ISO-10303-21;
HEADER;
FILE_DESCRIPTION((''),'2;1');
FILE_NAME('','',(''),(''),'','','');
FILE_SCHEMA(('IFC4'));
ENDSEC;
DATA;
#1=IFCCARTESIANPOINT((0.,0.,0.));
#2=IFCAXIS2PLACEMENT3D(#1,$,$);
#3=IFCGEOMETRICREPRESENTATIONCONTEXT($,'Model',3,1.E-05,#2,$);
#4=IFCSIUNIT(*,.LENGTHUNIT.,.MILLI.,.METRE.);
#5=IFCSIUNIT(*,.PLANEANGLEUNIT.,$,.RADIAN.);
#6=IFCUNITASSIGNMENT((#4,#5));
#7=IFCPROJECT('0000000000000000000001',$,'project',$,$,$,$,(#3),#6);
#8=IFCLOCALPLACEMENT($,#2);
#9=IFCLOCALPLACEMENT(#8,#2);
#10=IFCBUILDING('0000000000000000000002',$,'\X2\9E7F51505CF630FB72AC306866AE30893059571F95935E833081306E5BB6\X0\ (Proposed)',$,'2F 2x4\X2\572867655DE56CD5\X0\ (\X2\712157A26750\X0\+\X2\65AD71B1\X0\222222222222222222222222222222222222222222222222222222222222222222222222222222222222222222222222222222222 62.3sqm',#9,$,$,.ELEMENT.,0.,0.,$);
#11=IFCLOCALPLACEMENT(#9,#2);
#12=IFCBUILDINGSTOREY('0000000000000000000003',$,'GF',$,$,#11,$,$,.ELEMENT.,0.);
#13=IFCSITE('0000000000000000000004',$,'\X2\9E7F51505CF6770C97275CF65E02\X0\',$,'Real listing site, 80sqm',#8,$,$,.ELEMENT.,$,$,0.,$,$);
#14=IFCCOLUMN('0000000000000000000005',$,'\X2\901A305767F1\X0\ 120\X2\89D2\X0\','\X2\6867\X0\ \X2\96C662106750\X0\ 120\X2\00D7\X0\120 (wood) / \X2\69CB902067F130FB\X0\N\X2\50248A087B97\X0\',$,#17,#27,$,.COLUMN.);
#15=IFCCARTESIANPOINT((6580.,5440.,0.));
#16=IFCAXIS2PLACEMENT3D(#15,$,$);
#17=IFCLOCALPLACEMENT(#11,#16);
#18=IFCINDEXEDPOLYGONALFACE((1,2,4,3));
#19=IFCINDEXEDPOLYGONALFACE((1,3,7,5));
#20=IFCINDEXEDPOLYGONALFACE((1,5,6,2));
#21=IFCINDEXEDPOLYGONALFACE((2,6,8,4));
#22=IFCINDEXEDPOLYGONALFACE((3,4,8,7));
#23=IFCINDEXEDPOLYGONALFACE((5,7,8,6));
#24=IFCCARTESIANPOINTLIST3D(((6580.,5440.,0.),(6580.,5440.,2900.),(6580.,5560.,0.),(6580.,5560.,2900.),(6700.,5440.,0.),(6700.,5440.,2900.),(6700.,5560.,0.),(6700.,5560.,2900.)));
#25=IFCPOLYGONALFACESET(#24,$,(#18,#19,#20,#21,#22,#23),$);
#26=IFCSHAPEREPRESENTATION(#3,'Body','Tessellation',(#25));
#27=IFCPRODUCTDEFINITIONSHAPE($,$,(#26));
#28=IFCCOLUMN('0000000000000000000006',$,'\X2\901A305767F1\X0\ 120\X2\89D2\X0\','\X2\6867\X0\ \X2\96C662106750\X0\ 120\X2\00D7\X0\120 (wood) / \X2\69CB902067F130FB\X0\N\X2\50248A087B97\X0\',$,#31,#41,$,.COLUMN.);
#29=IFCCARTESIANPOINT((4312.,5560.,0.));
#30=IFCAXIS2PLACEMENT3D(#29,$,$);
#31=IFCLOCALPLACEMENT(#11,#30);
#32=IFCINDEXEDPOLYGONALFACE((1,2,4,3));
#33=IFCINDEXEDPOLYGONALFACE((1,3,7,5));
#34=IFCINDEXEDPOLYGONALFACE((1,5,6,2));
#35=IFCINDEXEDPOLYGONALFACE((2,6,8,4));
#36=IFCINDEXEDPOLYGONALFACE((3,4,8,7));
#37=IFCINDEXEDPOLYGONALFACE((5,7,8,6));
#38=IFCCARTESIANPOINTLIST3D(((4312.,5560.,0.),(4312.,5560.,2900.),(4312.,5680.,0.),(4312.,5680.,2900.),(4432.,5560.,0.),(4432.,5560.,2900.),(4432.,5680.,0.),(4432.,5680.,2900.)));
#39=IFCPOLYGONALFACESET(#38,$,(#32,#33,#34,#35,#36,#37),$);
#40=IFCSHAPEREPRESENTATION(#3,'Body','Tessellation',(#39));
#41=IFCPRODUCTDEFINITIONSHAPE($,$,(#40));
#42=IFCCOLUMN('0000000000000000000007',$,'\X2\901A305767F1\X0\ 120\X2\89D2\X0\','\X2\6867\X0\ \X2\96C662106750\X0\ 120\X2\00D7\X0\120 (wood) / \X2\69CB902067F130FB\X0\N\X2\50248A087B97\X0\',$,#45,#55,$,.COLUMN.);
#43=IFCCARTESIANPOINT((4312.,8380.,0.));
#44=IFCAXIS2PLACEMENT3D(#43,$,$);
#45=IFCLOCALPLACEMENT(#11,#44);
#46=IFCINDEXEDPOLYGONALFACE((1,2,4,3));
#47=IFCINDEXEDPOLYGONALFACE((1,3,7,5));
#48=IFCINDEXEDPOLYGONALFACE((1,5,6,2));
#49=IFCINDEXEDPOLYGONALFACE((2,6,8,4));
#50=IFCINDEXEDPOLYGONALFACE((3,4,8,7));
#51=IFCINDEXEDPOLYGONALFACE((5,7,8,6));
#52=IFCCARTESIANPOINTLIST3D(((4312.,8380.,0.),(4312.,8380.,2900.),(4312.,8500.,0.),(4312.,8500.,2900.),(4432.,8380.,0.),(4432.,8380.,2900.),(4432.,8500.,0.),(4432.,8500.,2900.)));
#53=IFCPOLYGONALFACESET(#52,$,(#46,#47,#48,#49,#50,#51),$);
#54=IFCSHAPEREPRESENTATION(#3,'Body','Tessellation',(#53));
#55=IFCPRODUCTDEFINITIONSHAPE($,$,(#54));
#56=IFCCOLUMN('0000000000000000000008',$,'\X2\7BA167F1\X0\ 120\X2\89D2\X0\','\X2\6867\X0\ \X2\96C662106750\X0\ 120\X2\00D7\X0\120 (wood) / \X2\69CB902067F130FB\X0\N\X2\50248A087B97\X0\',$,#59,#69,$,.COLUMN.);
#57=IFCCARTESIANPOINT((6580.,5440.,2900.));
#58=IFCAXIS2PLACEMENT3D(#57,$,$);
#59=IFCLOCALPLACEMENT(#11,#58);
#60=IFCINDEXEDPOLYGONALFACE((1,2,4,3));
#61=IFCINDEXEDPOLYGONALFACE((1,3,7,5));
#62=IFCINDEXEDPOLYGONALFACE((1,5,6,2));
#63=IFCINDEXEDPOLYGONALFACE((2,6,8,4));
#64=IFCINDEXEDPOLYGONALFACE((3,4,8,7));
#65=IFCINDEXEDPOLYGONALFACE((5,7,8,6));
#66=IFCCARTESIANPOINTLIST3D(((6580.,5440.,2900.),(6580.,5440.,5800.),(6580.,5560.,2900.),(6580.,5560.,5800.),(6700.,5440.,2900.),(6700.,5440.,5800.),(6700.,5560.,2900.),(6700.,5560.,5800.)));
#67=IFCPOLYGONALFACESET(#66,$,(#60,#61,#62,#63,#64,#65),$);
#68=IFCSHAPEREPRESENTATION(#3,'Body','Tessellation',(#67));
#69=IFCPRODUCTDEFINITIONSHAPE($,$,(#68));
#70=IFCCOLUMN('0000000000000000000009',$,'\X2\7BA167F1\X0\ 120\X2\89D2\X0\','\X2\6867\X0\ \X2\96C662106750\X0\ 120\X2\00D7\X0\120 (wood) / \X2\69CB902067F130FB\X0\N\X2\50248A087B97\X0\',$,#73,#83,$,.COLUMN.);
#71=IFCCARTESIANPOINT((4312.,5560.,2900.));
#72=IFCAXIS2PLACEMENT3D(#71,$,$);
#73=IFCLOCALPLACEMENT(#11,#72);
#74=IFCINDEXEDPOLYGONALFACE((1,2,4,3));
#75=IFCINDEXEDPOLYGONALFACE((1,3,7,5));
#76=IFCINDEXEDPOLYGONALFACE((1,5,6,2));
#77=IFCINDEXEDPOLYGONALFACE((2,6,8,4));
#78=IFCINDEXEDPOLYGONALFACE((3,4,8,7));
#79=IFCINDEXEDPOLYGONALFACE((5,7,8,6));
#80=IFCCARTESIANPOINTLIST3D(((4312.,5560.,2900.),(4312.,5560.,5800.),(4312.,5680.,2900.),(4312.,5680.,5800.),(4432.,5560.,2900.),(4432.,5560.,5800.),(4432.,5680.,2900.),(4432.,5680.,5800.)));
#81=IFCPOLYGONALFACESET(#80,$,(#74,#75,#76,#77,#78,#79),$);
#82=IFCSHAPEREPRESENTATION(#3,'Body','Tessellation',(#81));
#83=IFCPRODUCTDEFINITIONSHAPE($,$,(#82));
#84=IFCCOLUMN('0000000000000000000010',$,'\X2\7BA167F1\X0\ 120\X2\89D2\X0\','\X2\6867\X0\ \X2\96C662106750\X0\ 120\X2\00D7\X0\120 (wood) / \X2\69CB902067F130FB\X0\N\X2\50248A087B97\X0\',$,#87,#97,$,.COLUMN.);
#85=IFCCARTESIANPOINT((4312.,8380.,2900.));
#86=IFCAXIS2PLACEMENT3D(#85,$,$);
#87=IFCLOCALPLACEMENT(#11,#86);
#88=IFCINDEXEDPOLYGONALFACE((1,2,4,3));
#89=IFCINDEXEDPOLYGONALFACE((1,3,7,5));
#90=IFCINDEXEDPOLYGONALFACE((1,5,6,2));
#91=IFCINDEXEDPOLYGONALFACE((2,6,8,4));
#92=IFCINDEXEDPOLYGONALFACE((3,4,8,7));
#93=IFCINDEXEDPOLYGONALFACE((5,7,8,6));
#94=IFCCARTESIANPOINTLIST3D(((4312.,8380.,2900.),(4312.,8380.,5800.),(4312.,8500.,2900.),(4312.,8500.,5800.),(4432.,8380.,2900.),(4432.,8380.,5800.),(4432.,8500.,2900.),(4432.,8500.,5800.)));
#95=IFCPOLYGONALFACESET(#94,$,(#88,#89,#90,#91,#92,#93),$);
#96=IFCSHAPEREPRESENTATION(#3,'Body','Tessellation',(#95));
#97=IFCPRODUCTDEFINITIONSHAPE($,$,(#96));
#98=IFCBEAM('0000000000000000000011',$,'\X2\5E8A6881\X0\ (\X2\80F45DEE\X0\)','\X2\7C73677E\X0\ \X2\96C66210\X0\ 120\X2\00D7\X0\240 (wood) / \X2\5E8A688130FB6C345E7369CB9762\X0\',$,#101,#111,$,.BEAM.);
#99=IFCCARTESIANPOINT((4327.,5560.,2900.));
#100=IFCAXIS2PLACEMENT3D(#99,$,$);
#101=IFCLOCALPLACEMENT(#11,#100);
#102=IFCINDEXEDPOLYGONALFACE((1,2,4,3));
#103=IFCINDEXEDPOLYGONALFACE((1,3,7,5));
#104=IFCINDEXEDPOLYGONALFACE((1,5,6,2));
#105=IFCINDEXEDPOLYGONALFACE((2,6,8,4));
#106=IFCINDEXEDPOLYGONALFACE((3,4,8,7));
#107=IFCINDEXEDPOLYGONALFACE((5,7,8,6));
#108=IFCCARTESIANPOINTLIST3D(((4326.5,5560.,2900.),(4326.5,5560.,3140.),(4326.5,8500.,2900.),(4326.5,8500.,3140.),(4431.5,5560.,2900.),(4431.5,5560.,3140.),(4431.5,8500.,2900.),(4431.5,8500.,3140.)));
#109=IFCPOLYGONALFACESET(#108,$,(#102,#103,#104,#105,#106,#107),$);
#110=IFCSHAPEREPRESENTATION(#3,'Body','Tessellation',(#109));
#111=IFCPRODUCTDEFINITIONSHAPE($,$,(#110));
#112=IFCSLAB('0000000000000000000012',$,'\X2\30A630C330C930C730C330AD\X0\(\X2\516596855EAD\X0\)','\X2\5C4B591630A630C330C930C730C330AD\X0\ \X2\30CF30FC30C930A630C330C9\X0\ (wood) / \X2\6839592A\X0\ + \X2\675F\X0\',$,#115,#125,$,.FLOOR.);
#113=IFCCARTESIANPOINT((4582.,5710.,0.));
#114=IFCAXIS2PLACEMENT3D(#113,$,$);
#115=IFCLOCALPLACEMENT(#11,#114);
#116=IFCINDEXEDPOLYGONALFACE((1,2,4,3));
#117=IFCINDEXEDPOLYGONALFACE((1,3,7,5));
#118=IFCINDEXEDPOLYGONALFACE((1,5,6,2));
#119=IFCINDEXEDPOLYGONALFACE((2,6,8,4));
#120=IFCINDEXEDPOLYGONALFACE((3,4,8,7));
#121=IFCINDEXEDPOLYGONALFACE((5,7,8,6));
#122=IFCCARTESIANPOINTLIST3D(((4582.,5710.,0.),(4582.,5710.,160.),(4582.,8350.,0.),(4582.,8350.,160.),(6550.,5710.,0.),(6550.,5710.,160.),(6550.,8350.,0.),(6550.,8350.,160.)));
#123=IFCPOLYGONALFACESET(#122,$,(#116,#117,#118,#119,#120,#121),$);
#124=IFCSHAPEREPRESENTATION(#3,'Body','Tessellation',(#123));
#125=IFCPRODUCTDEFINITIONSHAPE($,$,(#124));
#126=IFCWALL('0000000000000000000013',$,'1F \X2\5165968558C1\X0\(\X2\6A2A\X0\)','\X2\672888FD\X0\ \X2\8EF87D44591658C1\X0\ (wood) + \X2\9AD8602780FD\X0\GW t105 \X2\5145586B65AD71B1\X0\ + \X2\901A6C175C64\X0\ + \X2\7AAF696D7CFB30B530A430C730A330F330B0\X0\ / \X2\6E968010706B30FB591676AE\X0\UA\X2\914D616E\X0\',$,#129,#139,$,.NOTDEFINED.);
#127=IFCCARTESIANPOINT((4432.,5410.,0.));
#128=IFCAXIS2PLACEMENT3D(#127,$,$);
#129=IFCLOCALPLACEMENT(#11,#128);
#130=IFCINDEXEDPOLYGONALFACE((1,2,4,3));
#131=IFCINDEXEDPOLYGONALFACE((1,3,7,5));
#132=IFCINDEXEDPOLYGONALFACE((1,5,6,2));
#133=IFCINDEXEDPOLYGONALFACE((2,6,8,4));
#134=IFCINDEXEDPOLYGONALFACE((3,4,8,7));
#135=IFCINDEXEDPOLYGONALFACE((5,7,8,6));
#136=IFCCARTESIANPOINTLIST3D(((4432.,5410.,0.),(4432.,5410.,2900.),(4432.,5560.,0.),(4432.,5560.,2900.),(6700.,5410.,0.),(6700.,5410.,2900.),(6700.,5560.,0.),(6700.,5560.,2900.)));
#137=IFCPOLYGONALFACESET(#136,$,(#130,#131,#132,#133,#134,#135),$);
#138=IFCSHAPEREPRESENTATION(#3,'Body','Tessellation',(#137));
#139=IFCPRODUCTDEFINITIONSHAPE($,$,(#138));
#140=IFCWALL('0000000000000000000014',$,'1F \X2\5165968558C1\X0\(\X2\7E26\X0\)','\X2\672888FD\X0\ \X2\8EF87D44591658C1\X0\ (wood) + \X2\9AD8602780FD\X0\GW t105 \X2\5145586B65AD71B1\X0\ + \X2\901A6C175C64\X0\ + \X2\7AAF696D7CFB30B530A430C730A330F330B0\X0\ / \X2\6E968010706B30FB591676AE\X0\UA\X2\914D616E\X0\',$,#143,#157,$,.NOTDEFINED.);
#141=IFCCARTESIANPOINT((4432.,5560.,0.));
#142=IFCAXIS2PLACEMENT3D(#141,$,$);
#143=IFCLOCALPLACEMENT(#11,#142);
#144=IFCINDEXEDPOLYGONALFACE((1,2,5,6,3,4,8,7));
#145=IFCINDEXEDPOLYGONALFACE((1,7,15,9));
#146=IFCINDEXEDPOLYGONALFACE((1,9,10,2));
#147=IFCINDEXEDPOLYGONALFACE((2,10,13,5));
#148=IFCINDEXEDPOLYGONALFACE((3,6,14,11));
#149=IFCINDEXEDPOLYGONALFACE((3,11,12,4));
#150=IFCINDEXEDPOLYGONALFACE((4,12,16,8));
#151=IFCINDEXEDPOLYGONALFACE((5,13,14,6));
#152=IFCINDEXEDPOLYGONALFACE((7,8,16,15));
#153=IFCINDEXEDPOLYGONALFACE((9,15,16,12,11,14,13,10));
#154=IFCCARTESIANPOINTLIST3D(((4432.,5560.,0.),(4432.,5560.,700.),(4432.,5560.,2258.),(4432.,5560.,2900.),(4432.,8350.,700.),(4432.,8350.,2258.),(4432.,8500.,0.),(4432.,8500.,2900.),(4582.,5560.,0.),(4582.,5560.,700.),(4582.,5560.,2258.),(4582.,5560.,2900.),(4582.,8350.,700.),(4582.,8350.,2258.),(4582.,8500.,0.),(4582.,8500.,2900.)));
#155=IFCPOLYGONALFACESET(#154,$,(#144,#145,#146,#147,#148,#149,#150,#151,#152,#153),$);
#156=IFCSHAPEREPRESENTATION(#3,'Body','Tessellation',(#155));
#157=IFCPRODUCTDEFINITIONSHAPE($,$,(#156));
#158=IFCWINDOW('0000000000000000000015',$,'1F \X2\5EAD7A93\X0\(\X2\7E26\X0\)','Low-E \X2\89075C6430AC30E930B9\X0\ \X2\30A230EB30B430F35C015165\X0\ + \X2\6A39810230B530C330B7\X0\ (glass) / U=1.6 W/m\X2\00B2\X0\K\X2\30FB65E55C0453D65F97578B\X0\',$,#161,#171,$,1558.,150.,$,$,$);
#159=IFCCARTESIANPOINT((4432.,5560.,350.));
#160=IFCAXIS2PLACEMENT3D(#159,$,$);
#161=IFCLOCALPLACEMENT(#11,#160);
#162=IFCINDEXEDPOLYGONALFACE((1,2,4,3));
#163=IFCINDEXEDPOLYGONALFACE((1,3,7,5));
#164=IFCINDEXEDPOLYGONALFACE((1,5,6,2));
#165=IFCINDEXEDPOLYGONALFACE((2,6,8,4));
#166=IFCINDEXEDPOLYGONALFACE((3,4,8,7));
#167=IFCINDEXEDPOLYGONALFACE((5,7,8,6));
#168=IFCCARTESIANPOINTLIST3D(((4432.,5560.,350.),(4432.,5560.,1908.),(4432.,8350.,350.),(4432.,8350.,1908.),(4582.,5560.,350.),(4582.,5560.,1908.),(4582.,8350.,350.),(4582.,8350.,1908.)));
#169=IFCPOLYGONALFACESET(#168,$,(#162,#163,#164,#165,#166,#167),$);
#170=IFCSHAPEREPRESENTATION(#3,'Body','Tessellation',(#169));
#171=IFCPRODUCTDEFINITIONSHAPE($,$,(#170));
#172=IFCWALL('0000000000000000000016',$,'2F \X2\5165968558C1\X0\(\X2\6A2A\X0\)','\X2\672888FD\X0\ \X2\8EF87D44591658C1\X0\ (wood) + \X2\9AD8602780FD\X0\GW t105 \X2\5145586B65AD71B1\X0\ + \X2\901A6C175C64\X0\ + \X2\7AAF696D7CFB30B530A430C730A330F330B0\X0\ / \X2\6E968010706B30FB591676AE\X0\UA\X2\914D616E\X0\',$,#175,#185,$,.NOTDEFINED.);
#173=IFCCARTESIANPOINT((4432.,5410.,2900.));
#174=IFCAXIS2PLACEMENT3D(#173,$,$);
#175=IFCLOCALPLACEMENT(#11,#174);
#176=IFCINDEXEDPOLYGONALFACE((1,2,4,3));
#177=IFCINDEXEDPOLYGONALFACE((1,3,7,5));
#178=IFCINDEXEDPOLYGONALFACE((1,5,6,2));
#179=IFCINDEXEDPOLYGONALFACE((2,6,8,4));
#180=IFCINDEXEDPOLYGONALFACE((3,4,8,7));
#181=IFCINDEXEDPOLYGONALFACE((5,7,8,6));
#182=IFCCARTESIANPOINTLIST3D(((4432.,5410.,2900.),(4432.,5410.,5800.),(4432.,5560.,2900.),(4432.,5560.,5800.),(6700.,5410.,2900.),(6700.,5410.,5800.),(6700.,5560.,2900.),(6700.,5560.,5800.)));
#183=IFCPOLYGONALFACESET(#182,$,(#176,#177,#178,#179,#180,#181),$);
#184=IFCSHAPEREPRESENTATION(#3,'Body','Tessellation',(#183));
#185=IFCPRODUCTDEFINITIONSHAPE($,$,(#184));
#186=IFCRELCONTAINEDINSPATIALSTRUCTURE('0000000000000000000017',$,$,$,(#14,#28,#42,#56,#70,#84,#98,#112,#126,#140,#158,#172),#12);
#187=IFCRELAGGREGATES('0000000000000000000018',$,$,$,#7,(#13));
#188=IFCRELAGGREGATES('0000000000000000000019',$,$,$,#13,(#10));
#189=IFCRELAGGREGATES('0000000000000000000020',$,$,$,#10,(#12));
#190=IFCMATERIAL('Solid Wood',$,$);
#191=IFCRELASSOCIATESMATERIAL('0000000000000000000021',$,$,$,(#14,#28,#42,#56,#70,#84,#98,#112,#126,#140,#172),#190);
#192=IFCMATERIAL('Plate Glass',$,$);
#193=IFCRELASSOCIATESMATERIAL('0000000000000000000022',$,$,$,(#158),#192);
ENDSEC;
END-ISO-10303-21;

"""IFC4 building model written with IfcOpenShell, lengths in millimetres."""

from ifc_helpers import new_model, si_unit, frame, frame_2d, origin, place, context, project, spatial, rectangle, extrude, material, element, fill, save


model = new_model("IFC4")

# Units and contexts
model_context = context("Model", 3, precision=1e-05, world=origin())
ifc_project = project(units=[si_unit("LENGTHUNIT", "METRE", prefix="MILLI"), si_unit("PLANEANGLEUNIT", "RADIAN")], contexts=[model_context])

# Site, building, storey
site_placement = place(None, origin())
site = spatial("IfcSite", under=ifc_project, at=site_placement, Name="鹿児島県霧島市", ObjectType="Real listing site, 80sqm", CompositionType="ELEMENT", RefElevation=0.0)
building_placement = place(site_placement, origin())
building = spatial("IfcBuilding", under=site, at=building_placement, Name="鹿児島・犬と暮らす土間広めの家 (Proposed)", ObjectType="2F 2x4在来工法 (無垢材+断熱222222222222222222222222222222222222222222222222222222222222222222222222222222222222222222222222222222222 62.3sqm", CompositionType="ELEMENT", ElevationOfRefHeight=0.0, ElevationOfTerrain=0.0)
storey_placement = place(building_placement, origin())
storey = spatial("IfcBuildingStorey", under=building, at=storey_placement, Name="GF", CompositionType="ELEMENT", Elevation=0.0)

# Columns
ifc_material_1 = material(Name="Solid Wood")
column_1_placement = place(storey_placement, frame((6580.0, 5440.0, 0.0)))
element("IfcColumn", 1, at=column_1_placement, inside=storey, material=ifc_material_1, Name="通し柱 120角", Description="桧 集成材 120×120 (wood) / 構造柱・N値計算", PredefinedType="COLUMN", context=model_context, shape_type="SweptSolid", body=[
    extrude(rectangle(XDim=120.0, YDim=120.0, at=frame_2d((60.0, 60.0))), frame((6580.0, 5440.0, 0.0)), (0.0, 0.0, 1.0), 2900.0),
])
column_2_placement = place(storey_placement, frame((4312.0, 5560.0, 0.0)))
element("IfcColumn", 2, at=column_2_placement, inside=storey, material=ifc_material_1, Name="通し柱 120角", Description="桧 集成材 120×120 (wood) / 構造柱・N値計算", PredefinedType="COLUMN", context=model_context, shape_type="SweptSolid", body=[
    extrude(rectangle(XDim=120.0, YDim=120.0, at=frame_2d((60.0, 60.0))), frame((4312.0, 5560.0, 0.0)), (0.0, 0.0, 1.0), 2900.0),
])
column_3_placement = place(storey_placement, frame((4312.0, 8380.0, 0.0)))
element("IfcColumn", 3, at=column_3_placement, inside=storey, material=ifc_material_1, Name="通し柱 120角", Description="桧 集成材 120×120 (wood) / 構造柱・N値計算", PredefinedType="COLUMN", context=model_context, shape_type="SweptSolid", body=[
    extrude(rectangle(XDim=120.0, YDim=120.0, at=frame_2d((60.0, 60.0))), frame((4312.0, 8380.0, 0.0)), (0.0, 0.0, 1.0), 2900.0),
])
column_4_placement = place(storey_placement, frame((6580.0, 5440.0, 2900.0)))
element("IfcColumn", 4, at=column_4_placement, inside=storey, material=ifc_material_1, Name="管柱 120角", Description="桧 集成材 120×120 (wood) / 構造柱・N値計算", PredefinedType="COLUMN", context=model_context, shape_type="SweptSolid", body=[
    extrude(rectangle(XDim=120.0, YDim=120.0, at=frame_2d((60.0, 60.0))), frame((6580.0, 5440.0, 2900.0)), (0.0, 0.0, 1.0), 2900.0),
])
column_5_placement = place(storey_placement, frame((4312.0, 5560.0, 2900.0)))
element("IfcColumn", 5, at=column_5_placement, inside=storey, material=ifc_material_1, Name="管柱 120角", Description="桧 集成材 120×120 (wood) / 構造柱・N値計算", PredefinedType="COLUMN", context=model_context, shape_type="SweptSolid", body=[
    extrude(rectangle(XDim=120.0, YDim=120.0, at=frame_2d((60.0, 60.0))), frame((4312.0, 5560.0, 2900.0)), (0.0, 0.0, 1.0), 2900.0),
])
column_6_placement = place(storey_placement, frame((4312.0, 8380.0, 2900.0)))
element("IfcColumn", 6, at=column_6_placement, inside=storey, material=ifc_material_1, Name="管柱 120角", Description="桧 集成材 120×120 (wood) / 構造柱・N値計算", PredefinedType="COLUMN", context=model_context, shape_type="SweptSolid", body=[
    extrude(rectangle(XDim=120.0, YDim=120.0, at=frame_2d((60.0, 60.0))), frame((4312.0, 8380.0, 2900.0)), (0.0, 0.0, 1.0), 2900.0),
])

# Beam
beam_1_placement = place(storey_placement, frame((4327.0, 5560.0, 2900.0)))
element("IfcBeam", 7, at=beam_1_placement, inside=storey, material=ifc_material_1, Name="床梁 (胴差)", Description="米松 集成 120×240 (wood) / 床梁・水平構面", PredefinedType="BEAM", context=model_context, shape_type="SweptSolid", body=[
    extrude(rectangle(XDim=105.0, YDim=2940.0, at=frame_2d((52.0, 1470.0))), frame((4327.0, 5560.0, 2900.0)), (0.0, 0.0, 1.0), 240.0),
])

# Slab
slab_placement = place(storey_placement, frame((4582.0, 5710.0, 0.0)))
element("IfcSlab", 8, at=slab_placement, inside=storey, material=ifc_material_1, Name="ウッドデッキ(入隅庭)", Description="屋外ウッドデッキ ハードウッド (wood) / 根太 + 束", PredefinedType="FLOOR", context=model_context, shape_type="SweptSolid", body=[
    extrude(rectangle(XDim=1968.0, YDim=2640.0, at=frame_2d((984.0, 1320.0))), frame((4582.0, 5710.0, 0.0)), (0.0, 0.0, 1.0), 160.0),
])

# Wall
wall_1_placement = place(storey_placement, frame((4432.0, 5410.0, 0.0)))
element("IfcWall", 9, at=wall_1_placement, inside=storey, material=ifc_material_1, Name="1F 入隅壁(横)", Description="木製 軸組外壁 (wood) + 高性能GW t105 充填断熱 + 通気層 + 窯業系サイディング / 準耐火・外皮UA配慮", PredefinedType="NOTDEFINED", context=model_context, shape_type="SweptSolid", body=[
    extrude(rectangle(XDim=2268.0, YDim=150.0, at=frame_2d((1134.0, 75.0))), frame((4432.0, 5410.0, 0.0)), (0.0, 0.0, 1.0), 2900.0),
])

# Wall, opening, window
wall_2_placement = place(storey_placement, frame((4432.0, 5560.0, 0.0)))
wall_2 = element("IfcWall", 10, at=wall_2_placement, inside=storey, material=ifc_material_1, Name="1F 入隅壁(縦)", Description="木製 軸組外壁 (wood) + 高性能GW t105 充填断熱 + 通気層 + 窯業系サイディング / 準耐火・外皮UA配慮", PredefinedType="NOTDEFINED", context=model_context, shape_type="SweptSolid", body=[
    extrude(rectangle(XDim=150.0, YDim=2940.0, at=frame_2d((75.0, 1470.0))), frame((4432.0, 5560.0, 0.0)), (0.0, 0.0, 1.0), 2900.0),
])
opening_1_placement = place(storey_placement, frame((4432.0, 5560.0, 350.0)))
opening_1 = element("IfcOpeningElement", 11, at=opening_1_placement, cuts=wall_2, PredefinedType="NOTDEFINED", context=model_context, shape_type="SweptSolid", body=[
    extrude(rectangle(XDim=150.0, YDim=2790.0, at=frame_2d((75.0, 1395.0))), frame((4432.0, 5560.0, 350.0)), (0.0, 0.0, 1.0), 1558.0),
])
ifc_material_2 = material(Name="Plate Glass")
window_1_placement = place(storey_placement, frame((4432.0, 5560.0, 350.0)))
window_1 = element("IfcWindow", 12, at=window_1_placement, inside=storey, material=ifc_material_2, Name="1F 庭窓(縦)", Description="Low-E 複層ガラス アルゴン封入 + 樹脂サッシ (glass) / U=1.6 W/m²K・日射取得型", OverallHeight=1558.0, OverallWidth=150.0, context=model_context, shape_type="SweptSolid", body=[
    extrude(rectangle(XDim=150.0, YDim=2790.0, at=frame_2d((75.0, 1395.0))), frame((4432.0, 5560.0, 350.0)), (0.0, 0.0, 1.0), 1558.0),
])
fill(opening_1, window_1)

# Wall
wall_3_placement = place(storey_placement, frame((4432.0, 5410.0, 2900.0)))
element("IfcWall", 13, at=wall_3_placement, inside=storey, material=ifc_material_1, Name="2F 入隅壁(横)", Description="木製 軸組外壁 (wood) + 高性能GW t105 充填断熱 + 通気層 + 窯業系サイディング / 準耐火・外皮UA配慮", PredefinedType="NOTDEFINED", context=model_context, shape_type="SweptSolid", body=[
    extrude(rectangle(XDim=2268.0, YDim=150.0, at=frame_2d((1134.0, 75.0))), frame((4432.0, 5410.0, 2900.0)), (0.0, 0.0, 1.0), 2900.0),
])

save(model, "model.ifc")
